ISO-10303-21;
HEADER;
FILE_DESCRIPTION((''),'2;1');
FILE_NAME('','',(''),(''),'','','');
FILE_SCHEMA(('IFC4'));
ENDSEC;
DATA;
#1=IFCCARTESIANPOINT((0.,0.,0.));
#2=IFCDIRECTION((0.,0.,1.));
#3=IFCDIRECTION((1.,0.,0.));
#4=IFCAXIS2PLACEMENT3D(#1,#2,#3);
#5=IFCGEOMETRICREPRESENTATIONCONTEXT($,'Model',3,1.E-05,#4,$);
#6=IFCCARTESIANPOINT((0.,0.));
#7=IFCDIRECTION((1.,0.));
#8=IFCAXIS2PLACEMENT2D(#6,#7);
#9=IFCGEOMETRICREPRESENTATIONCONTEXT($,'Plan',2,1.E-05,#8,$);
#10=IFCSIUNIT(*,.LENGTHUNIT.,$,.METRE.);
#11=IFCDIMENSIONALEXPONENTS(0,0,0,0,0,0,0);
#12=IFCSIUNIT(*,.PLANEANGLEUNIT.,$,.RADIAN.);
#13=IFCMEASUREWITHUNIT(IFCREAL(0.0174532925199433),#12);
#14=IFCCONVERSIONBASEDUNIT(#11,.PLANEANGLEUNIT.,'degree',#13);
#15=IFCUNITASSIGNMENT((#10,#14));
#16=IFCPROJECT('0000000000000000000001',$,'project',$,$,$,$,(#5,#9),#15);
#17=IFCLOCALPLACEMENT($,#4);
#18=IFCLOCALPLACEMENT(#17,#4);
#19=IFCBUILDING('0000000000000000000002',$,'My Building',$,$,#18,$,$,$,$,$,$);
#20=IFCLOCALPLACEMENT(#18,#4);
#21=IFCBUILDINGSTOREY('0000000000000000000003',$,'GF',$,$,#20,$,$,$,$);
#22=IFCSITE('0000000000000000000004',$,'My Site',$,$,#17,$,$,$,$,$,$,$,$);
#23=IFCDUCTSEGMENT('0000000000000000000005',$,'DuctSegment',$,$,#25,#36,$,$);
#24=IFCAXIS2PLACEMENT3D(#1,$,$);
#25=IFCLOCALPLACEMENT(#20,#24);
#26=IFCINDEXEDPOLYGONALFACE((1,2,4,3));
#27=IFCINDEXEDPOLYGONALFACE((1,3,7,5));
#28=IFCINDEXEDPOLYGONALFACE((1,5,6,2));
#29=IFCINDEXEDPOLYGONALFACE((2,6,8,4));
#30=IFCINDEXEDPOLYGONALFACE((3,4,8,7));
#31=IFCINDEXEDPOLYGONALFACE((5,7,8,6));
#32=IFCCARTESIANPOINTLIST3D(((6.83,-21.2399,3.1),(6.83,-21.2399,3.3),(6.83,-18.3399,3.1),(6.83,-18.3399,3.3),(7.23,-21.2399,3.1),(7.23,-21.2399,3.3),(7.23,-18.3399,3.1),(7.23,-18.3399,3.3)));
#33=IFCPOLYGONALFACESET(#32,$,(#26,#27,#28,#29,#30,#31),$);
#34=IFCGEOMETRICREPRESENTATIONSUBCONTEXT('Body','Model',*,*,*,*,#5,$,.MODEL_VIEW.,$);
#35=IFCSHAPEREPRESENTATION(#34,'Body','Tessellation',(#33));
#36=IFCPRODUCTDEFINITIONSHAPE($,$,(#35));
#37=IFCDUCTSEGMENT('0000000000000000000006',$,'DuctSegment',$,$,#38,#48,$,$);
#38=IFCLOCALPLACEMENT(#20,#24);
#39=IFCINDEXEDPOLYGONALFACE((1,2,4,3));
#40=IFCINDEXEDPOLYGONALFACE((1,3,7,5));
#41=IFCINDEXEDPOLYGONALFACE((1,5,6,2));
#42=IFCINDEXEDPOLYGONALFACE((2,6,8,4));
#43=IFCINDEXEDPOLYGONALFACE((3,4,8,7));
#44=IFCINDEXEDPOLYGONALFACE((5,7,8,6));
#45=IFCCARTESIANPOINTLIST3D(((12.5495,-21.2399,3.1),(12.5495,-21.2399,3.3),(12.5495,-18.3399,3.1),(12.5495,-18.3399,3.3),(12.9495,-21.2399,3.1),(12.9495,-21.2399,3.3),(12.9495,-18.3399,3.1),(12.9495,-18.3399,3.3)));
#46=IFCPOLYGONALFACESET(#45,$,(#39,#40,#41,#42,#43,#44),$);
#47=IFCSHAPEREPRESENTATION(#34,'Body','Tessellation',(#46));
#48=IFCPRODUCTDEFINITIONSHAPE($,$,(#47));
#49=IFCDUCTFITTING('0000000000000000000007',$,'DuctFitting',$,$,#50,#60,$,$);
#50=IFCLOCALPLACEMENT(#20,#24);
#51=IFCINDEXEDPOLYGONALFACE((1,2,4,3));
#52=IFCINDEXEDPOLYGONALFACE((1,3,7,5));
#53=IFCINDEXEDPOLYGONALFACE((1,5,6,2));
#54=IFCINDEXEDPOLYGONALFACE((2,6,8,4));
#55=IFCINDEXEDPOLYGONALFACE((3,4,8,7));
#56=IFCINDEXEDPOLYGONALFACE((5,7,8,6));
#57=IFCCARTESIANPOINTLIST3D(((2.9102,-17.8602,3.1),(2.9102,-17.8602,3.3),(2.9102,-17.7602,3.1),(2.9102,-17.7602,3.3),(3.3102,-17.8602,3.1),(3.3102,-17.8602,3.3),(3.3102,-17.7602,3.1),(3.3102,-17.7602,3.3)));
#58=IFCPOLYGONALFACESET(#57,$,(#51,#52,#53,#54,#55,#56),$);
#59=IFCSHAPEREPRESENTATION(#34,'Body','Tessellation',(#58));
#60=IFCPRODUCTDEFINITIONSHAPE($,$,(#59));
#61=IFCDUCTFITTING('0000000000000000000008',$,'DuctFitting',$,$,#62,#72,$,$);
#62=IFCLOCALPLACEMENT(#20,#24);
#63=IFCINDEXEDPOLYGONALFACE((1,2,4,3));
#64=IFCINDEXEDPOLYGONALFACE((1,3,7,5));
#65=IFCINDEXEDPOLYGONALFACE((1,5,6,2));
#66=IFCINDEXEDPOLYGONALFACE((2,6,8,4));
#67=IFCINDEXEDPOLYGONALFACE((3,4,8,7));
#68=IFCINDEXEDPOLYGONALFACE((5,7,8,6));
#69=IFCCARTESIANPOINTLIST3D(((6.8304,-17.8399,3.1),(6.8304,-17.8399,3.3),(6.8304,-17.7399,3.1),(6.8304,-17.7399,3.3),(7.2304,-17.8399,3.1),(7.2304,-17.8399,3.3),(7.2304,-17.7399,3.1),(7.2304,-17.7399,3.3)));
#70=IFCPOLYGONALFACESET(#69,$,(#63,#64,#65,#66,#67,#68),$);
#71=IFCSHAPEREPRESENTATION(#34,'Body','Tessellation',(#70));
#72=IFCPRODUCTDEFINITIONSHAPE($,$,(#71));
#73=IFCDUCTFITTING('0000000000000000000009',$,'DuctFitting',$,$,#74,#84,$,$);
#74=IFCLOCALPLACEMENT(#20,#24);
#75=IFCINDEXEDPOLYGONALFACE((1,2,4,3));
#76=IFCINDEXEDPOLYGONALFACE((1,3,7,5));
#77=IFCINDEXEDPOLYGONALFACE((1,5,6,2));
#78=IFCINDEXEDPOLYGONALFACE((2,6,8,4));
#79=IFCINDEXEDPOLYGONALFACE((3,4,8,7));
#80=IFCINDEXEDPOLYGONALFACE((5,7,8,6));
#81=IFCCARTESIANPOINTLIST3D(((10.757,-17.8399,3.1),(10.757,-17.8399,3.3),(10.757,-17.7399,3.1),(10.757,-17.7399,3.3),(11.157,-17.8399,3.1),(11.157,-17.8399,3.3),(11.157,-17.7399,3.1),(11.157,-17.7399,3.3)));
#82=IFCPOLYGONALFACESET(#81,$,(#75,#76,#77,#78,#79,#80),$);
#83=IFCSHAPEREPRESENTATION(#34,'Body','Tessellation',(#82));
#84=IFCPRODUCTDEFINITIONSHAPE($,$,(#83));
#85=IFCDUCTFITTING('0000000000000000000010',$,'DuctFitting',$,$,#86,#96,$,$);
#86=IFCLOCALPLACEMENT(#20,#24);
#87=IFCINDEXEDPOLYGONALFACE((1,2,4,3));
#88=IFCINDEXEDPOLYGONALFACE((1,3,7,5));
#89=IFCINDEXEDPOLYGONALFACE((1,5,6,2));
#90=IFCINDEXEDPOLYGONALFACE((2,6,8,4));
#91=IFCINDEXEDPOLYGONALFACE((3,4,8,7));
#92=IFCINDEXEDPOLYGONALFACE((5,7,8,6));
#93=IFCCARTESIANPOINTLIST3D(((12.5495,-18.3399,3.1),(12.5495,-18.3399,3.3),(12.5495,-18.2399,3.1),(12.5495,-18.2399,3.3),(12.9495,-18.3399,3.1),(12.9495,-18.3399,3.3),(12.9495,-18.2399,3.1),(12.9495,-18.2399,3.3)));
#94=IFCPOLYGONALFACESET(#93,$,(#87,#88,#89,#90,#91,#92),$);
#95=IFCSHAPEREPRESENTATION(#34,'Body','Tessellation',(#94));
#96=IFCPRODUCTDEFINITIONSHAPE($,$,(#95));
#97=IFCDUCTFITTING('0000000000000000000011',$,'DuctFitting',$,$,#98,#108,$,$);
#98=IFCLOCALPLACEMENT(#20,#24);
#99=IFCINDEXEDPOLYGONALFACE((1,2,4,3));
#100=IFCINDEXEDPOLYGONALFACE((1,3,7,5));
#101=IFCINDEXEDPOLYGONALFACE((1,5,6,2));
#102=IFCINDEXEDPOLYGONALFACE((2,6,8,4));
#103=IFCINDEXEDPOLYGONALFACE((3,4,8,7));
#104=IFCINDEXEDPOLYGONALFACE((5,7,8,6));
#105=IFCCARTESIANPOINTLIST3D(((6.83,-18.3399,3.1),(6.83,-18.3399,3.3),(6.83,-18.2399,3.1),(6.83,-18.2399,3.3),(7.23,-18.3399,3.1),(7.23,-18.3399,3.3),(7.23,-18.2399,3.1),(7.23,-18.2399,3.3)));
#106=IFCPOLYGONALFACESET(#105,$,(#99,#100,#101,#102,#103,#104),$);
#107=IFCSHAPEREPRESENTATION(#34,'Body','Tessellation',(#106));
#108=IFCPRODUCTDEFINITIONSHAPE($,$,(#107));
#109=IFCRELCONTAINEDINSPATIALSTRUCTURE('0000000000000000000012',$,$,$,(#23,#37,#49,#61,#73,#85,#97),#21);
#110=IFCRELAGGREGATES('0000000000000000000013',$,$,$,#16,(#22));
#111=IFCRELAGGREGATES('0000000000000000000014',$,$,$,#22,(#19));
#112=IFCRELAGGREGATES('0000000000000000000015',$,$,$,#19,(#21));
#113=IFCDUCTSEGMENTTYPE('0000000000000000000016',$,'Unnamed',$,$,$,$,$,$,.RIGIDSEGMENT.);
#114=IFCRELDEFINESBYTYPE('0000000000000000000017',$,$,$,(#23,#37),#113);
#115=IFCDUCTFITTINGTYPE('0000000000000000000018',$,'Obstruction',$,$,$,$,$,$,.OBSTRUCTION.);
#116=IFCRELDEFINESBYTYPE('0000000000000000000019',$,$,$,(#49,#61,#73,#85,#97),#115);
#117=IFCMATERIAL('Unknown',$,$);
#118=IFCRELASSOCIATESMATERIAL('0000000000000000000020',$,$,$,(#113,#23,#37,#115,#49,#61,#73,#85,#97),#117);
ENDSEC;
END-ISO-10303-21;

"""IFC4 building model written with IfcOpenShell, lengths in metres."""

from ifc_helpers import new_model, entity, si_unit, converted_unit, frame, origin_with_axes, origin_2d_with_axis, place, context, subcontext, project, spatial, rectangle, extrude, material, material_profile, profile_set, profile_usage, type_object, element, save


model = new_model("IFC4")

# Units and contexts
model_context = context("Model", 3, precision=1e-05, world=origin_with_axes())
plan_context = context("Plan", 2, precision=1e-05, world=origin_2d_with_axis())
body_context_1 = subcontext(model_context, "Body", "Model", "MODEL_VIEW")
ifc_project = project(units=[si_unit("LENGTHUNIT", "METRE"), converted_unit("PLANEANGLEUNIT", "degree", entity("IfcReal", 0.0174532925199433), si_unit("PLANEANGLEUNIT", "RADIAN"), dimensions=[0, 0, 0, 0, 0, 0, 0])], contexts=[model_context, plan_context])

# Site, building, storey
site_placement = place(None, origin_with_axes())
site = spatial("IfcSite", under=ifc_project, at=site_placement, Name="My Site")
building_placement = place(site_placement, origin_with_axes())
building = spatial("IfcBuilding", under=site, at=building_placement, Name="My Building")
storey_placement = place(building_placement, origin_with_axes())
storey = spatial("IfcBuildingStorey", under=building, at=storey_placement, Name="GF")

# Shared definitions
ifc_material = material(Name="Unknown")

# Duct segments
ifc_material_profile_1 = material_profile(ifc_material, rectangle(XDim=0.4, YDim=0.2))
ifc_profile_set_1 = profile_set([ifc_material_profile_1])
ifc_profile_usage_1 = profile_usage(ifc_profile_set_1, cardinal=5)
duct_segment_type = type_object("IfcDuctSegmentType", Name="Unnamed", PredefinedType="RIGIDSEGMENT", material=ifc_profile_set_1)
duct_segment_1_placement = place(storey_placement, frame((7.03, -18.3399, 3.2), z_axis=(0.0, -1.0, -0.000001), x_axis=(1.0, 0.0, 0.0)))
element("IfcDuctSegment", 1, at=duct_segment_1_placement, inside=storey, type_object=duct_segment_type, material=ifc_profile_usage_1, Name="DuctSegment", context=body_context_1, shape_type="SweptSolid", body=[
    extrude(rectangle(XDim=0.4, YDim=0.2), origin_with_axes(), (0.0, 0.0, 1.0), 2.9),
])
ifc_profile_usage_2 = profile_usage(ifc_profile_set_1, cardinal=5)
duct_segment_2_placement = place(storey_placement, frame((12.7495, -18.3399, 3.2), z_axis=(0.0, -1.0, -0.000001), x_axis=(1.0, 0.0, 0.0)))
element("IfcDuctSegment", 2, at=duct_segment_2_placement, inside=storey, type_object=duct_segment_type, material=ifc_profile_usage_2, Name="DuctSegment", context=body_context_1, shape_type="SweptSolid", body=[
    extrude(rectangle(XDim=0.4, YDim=0.2), origin_with_axes(), (0.0, 0.0, 1.0), 2.9),
])

# Duct fittings
ifc_material_profile_2 = material_profile(ifc_material, rectangle(XDim=0.4, YDim=0.2))
ifc_profile_set_2 = profile_set([ifc_material_profile_2])
ifc_profile_usage_3 = profile_usage(ifc_profile_set_2, cardinal=5)
duct_fitting_type = type_object("IfcDuctFittingType", Name="Obstruction", PredefinedType="OBSTRUCTION", material=ifc_profile_set_2)
duct_fitting_1_placement = place(storey_placement, frame((3.1102, -17.8602, 3.2), z_axis=(0.0, 1.0, 0.0), x_axis=(-1.0, 0.0, 0.0)))
element("IfcDuctFitting", 3, at=duct_fitting_1_placement, inside=storey, type_object=duct_fitting_type, material=ifc_profile_usage_3, Name="DuctFitting", context=body_context_1, shape_type="SweptSolid", body=[
    extrude(rectangle(XDim=0.4, YDim=0.2), origin_with_axes(), (0.0, 0.0, 1.0), 0.1),
])
ifc_profile_usage_4 = profile_usage(ifc_profile_set_2, cardinal=5)
duct_fitting_2_placement = place(storey_placement, frame((7.0304, -17.8399, 3.2), z_axis=(0.0, 1.0, -0.000001), x_axis=(-1.0, 0.0, 0.0)))
element("IfcDuctFitting", 4, at=duct_fitting_2_placement, inside=storey, type_object=duct_fitting_type, material=ifc_profile_usage_4, Name="DuctFitting", context=body_context_1, shape_type="SweptSolid", body=[
    extrude(rectangle(XDim=0.4, YDim=0.2), origin_with_axes(), (0.0, 0.0, 1.0), 0.1),
])
ifc_profile_usage_5 = profile_usage(ifc_profile_set_2, cardinal=5)
duct_fitting_3_placement = place(storey_placement, frame((10.957, -17.8399, 3.2), z_axis=(0.0, 1.0, -0.000001), x_axis=(-1.0, 0.0, 0.0)))
element("IfcDuctFitting", 5, at=duct_fitting_3_placement, inside=storey, type_object=duct_fitting_type, material=ifc_profile_usage_5, Name="DuctFitting", context=body_context_1, shape_type="SweptSolid", body=[
    extrude(rectangle(XDim=0.4, YDim=0.2), origin_with_axes(), (0.0, 0.0, 1.0), 0.1),
])
ifc_profile_usage_6 = profile_usage(ifc_profile_set_2, cardinal=5)
duct_fitting_4_placement = place(storey_placement, frame((12.7495, -18.2399, 3.2), z_axis=(0.0, -1.0, -0.000001), x_axis=(1.0, 0.0, 0.0)))
element("IfcDuctFitting", 6, at=duct_fitting_4_placement, inside=storey, type_object=duct_fitting_type, material=ifc_profile_usage_6, Name="DuctFitting", context=body_context_1, shape_type="SweptSolid", body=[
    extrude(rectangle(XDim=0.4, YDim=0.2), origin_with_axes(), (0.0, 0.0, 1.0), 0.1),
])
ifc_profile_usage_7 = profile_usage(ifc_profile_set_2, cardinal=5)
duct_fitting_5_placement = place(storey_placement, frame((7.03, -18.2399, 3.2), z_axis=(0.0, -1.0, -0.000001), x_axis=(1.0, 0.0, 0.0)))
element("IfcDuctFitting", 7, at=duct_fitting_5_placement, inside=storey, type_object=duct_fitting_type, material=ifc_profile_usage_7, Name="DuctFitting", context=body_context_1, shape_type="SweptSolid", body=[
    extrude(rectangle(XDim=0.4, YDim=0.2), origin_with_axes(), (0.0, 0.0, 1.0), 0.1),
])

save(model, "model.ifc")
